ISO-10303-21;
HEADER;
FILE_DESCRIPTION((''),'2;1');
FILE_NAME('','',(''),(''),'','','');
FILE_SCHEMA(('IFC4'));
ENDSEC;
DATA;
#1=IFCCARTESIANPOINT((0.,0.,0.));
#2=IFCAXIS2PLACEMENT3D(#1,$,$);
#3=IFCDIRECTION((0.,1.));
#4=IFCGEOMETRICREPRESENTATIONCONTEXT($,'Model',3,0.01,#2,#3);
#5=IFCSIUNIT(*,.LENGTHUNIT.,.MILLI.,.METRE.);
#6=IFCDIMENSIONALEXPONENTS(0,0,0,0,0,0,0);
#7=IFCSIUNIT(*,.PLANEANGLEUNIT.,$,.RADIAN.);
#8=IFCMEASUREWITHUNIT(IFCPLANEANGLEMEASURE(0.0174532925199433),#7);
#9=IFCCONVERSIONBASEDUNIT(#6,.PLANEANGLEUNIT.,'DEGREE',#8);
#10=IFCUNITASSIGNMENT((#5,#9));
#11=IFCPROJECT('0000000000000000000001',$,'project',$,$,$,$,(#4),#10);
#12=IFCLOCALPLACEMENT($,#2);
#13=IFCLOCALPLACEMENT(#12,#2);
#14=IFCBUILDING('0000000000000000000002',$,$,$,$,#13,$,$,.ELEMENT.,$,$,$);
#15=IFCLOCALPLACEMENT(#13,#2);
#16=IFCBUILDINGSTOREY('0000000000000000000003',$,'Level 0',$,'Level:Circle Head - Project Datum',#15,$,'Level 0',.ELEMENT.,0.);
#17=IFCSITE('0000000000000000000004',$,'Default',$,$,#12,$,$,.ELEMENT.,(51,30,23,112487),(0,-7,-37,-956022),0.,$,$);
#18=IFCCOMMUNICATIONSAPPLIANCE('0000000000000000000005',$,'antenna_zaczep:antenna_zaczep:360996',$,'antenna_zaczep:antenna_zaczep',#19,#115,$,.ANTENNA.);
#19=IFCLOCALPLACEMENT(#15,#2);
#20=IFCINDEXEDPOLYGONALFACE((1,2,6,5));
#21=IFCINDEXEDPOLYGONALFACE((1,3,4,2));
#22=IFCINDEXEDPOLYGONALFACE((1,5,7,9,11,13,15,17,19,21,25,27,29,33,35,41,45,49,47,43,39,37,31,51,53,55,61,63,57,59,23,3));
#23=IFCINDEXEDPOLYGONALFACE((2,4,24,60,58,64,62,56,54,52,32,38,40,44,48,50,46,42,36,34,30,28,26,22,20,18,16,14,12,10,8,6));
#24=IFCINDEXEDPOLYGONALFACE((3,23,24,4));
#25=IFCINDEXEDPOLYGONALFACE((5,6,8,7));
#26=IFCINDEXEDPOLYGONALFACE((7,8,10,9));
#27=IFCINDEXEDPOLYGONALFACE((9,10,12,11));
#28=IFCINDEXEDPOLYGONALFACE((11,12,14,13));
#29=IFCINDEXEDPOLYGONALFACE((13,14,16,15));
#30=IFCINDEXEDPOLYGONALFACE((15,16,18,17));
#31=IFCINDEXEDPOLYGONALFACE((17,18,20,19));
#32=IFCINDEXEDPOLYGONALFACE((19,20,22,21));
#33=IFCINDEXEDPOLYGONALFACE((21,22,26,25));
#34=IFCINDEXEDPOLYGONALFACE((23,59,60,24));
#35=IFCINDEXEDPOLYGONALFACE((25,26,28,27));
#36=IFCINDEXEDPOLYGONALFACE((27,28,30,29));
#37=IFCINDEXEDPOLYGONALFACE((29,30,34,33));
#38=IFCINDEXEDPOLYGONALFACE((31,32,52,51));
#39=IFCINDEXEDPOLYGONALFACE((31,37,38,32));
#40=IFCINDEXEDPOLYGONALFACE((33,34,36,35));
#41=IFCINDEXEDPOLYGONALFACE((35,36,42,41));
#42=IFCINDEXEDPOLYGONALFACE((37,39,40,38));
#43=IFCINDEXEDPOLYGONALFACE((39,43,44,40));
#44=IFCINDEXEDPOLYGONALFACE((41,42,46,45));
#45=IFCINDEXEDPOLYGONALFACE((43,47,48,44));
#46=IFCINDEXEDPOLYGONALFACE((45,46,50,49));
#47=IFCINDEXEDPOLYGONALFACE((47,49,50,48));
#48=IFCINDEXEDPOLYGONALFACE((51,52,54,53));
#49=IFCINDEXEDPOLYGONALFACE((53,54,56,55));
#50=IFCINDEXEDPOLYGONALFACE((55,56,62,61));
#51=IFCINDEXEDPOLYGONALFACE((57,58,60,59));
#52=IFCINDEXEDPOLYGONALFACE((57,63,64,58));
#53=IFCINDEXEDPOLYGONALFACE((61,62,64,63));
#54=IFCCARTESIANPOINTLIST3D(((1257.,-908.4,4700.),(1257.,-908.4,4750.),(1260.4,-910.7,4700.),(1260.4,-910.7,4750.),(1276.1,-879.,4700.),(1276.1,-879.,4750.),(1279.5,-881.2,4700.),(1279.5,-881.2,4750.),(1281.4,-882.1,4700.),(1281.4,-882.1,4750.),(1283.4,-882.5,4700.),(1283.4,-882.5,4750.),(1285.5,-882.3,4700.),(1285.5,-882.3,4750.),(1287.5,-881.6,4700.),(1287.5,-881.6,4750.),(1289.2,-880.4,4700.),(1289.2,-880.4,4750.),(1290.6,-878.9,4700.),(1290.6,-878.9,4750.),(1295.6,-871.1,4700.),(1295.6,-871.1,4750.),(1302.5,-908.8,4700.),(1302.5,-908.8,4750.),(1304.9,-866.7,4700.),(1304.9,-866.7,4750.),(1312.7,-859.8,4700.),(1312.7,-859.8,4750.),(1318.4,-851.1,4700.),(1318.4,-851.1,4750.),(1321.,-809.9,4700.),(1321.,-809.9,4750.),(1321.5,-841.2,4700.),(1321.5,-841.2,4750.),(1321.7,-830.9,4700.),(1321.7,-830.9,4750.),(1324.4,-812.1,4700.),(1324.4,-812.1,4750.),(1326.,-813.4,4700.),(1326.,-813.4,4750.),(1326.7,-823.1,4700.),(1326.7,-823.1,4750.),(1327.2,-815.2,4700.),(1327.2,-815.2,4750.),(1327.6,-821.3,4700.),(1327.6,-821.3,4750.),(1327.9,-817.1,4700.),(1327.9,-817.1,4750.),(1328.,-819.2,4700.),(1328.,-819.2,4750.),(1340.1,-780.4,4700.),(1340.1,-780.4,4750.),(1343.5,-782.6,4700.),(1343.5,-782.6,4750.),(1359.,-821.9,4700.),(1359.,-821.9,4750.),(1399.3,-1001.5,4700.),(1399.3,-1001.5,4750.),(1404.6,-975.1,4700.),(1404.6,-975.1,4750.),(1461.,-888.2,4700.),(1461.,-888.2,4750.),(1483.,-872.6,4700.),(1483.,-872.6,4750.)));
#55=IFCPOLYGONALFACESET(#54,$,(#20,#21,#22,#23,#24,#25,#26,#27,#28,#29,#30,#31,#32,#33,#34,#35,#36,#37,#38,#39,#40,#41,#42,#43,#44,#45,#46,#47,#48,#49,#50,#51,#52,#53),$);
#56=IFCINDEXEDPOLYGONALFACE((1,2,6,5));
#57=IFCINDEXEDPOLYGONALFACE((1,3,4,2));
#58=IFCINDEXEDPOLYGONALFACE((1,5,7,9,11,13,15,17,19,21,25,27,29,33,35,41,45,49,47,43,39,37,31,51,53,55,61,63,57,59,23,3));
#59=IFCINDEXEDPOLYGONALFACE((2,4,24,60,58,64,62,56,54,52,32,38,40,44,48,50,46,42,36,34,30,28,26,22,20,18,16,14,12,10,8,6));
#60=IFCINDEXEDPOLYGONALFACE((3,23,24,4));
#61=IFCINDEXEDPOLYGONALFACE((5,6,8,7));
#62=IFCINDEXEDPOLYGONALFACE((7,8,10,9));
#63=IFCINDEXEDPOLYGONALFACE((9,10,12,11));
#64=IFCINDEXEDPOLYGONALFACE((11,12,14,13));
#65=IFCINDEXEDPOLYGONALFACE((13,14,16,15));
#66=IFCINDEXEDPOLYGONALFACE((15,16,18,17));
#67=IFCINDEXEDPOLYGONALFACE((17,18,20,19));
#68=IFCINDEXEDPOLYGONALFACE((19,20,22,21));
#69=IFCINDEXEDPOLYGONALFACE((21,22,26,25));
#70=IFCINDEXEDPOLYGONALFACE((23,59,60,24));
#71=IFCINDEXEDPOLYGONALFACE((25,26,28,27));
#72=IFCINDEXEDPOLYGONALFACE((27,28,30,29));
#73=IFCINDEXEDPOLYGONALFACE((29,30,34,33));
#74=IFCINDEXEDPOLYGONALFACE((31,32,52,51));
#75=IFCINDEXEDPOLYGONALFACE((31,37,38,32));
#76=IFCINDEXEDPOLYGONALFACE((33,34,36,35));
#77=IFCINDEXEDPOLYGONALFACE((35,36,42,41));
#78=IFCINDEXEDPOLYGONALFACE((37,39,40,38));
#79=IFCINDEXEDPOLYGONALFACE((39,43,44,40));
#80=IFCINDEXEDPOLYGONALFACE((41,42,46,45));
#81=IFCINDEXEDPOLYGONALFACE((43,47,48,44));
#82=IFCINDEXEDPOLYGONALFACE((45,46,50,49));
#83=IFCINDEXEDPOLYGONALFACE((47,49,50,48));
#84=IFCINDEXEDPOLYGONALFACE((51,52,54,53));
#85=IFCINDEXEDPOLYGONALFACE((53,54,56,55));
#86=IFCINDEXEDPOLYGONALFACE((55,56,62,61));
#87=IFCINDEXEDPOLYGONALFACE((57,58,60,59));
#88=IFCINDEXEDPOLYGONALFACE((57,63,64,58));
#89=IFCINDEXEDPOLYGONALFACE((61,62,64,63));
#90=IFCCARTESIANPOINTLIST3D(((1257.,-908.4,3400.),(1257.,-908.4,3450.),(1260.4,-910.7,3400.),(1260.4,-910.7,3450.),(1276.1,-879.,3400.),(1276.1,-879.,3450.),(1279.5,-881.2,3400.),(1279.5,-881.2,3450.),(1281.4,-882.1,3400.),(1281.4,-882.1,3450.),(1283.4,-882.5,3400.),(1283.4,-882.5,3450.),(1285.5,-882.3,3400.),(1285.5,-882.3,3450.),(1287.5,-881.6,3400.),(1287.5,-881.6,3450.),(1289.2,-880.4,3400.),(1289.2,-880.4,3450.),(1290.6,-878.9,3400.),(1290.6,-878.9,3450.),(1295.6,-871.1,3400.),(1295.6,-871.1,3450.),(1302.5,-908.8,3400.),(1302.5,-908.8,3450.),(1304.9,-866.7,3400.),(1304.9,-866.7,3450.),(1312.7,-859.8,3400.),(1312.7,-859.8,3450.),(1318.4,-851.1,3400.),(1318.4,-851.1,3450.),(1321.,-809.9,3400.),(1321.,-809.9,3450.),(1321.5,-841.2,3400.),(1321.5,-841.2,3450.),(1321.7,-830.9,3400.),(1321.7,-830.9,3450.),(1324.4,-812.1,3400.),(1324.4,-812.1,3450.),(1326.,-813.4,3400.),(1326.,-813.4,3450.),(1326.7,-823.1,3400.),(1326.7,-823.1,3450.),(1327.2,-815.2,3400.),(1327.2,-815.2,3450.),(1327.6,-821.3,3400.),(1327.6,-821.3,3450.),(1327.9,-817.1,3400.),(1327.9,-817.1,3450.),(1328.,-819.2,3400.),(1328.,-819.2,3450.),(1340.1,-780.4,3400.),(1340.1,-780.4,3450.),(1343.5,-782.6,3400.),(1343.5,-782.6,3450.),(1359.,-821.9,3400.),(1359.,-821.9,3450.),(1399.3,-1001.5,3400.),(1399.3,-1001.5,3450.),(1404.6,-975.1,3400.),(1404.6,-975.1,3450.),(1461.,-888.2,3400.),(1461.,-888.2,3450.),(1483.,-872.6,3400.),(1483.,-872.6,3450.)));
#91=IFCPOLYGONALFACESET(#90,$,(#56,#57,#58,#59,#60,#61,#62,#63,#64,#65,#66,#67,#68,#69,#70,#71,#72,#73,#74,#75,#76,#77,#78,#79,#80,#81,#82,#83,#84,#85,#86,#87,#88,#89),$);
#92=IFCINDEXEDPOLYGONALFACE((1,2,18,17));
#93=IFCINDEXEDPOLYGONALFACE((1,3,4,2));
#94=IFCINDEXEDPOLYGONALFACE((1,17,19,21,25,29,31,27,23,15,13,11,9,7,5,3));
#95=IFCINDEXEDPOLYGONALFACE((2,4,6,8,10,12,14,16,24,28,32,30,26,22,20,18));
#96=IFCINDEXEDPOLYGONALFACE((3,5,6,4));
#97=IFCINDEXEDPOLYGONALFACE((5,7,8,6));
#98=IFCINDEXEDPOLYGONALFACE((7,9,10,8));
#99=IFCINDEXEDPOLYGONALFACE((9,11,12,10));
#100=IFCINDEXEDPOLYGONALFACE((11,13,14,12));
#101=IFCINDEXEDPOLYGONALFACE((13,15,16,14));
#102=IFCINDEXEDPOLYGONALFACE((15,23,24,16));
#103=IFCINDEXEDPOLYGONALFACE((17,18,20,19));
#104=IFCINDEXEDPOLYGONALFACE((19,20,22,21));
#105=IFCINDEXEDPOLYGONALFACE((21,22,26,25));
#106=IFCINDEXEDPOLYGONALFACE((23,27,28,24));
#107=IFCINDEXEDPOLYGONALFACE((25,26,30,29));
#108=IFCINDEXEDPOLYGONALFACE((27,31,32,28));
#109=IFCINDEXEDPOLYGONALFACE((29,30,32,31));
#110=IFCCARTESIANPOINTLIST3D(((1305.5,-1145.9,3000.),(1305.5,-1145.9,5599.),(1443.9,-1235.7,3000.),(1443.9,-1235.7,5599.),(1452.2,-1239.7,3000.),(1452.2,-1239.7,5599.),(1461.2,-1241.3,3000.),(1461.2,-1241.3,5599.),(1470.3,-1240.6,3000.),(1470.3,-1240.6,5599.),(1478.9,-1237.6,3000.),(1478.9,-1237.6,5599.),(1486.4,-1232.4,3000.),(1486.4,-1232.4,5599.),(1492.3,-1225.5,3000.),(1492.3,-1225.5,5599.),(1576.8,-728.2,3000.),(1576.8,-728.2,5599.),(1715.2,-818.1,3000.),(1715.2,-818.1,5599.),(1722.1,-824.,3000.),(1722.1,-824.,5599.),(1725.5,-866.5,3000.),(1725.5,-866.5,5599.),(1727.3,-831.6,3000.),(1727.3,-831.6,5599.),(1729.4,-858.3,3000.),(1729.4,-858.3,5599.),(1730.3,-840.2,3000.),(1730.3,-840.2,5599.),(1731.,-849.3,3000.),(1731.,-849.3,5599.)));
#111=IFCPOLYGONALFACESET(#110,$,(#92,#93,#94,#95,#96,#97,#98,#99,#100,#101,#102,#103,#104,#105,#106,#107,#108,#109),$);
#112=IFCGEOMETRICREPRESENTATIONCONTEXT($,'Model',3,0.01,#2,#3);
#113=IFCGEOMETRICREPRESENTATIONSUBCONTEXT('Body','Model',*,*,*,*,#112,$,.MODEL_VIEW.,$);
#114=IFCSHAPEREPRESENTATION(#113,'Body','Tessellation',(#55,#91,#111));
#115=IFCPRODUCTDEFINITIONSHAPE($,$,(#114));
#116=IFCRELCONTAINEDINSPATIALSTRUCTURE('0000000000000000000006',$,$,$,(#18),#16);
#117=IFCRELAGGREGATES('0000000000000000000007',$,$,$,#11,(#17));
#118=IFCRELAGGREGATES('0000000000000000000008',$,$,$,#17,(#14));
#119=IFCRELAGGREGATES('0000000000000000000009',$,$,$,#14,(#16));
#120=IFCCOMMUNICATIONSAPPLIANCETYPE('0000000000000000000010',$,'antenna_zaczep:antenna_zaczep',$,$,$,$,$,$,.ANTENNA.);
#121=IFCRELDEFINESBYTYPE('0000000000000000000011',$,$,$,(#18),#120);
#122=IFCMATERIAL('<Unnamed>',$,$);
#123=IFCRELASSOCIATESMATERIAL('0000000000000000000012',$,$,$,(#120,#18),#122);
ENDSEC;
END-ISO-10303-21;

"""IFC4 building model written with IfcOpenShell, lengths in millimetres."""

from ifc_helpers import new_model, entity, si_unit, converted_unit, direction, frame, origin, place, context, subcontext, project, spatial, line, arc, indexed_curve, outline, extrude, source, transform, mapped, material, type_object, type_shapes, element, save


model = new_model("IFC4")

# Units and contexts
model_context_1 = context("Model", 3, precision=0.01, world=origin(), true_north=direction((0.0, 1.0)))
model_context_2 = context("Model", 3, precision=0.01, world=origin(), true_north=direction((0.0, 1.0)))
body_context = subcontext(model_context_2, "Body", "Model", "MODEL_VIEW")
ifc_project = project(units=[si_unit("LENGTHUNIT", "METRE", prefix="MILLI"), converted_unit("PLANEANGLEUNIT", "DEGREE", entity("IfcPlaneAngleMeasure", 0.0174532925199433), si_unit("PLANEANGLEUNIT", "RADIAN"), dimensions=[0, 0, 0, 0, 0, 0, 0])], contexts=[model_context_1])

# Site, building, storey
site_placement = place(None, origin())
site = spatial("IfcSite", under=ifc_project, at=site_placement, Name="Default", CompositionType="ELEMENT", RefLatitude=(51, 30, 23, 112487), RefLongitude=(0, -7, -37, -956022), RefElevation=0.0)
building_placement = place(site_placement, origin())
building = spatial("IfcBuilding", under=site, at=building_placement, CompositionType="ELEMENT")
storey_placement = place(building_placement, origin())
storey = spatial("IfcBuildingStorey", under=building, at=storey_placement, Name="Level 0", ObjectType="Level:Circle Head - Project Datum", LongName="Level 0", CompositionType="ELEMENT", Elevation=0.0)

# Communications appliance
ifc_material_1 = material(Name="<Unnamed>")
communications_appliance_type = type_object("IfcCommunicationsApplianceType", Name="antenna_zaczep:antenna_zaczep", PredefinedType="ANTENNA", material=ifc_material_1)
shared_shape = source(origin(), body_context, "Body", "SweptSolid", [
    extrude(outline(indexed_curve([(-76.8, -125.5), (76.8, -125.5), (51.8, -115.5), (51.8, 6.1), (76.3, 40.5), (76.3, 44.5), (41.2, 44.5), (41.2, 40.5), (38.9, 34.8), (33.2, 32.5), (24.0, 32.5), (0.0, 23.9), (-24.0, 32.5), (-33.2, 32.5), (-38.9, 34.8), (-41.2, 40.5), (-41.2, 44.5), (-76.3, 44.5), (-76.3, 40.5), (-51.8, 6.1), (-51.8, -115.5)], segments=[line(1, 2, 3, 4, 5, 6, 7, 8), arc(8, 9, 10), line(10, 11), arc(11, 12, 13), line(13, 14), arc(14, 15, 16), line(16, 17, 18, 19, 20, 21, 1)], self_intersect=False)), frame((0.0, 61.4, 1700.0), z_axis=(0.0, 0.0, 1.0), x_axis=(-1.0, 0.0, 0.0)), (0.0, 0.0, 1.0), 50.0),
    extrude(outline(indexed_curve([(-76.8, -125.5), (76.8, -125.5), (51.8, -115.5), (51.8, 6.1), (76.3, 40.5), (76.3, 44.5), (41.2, 44.5), (41.2, 40.5), (38.9, 34.8), (33.2, 32.5), (24.0, 32.5), (0.0, 23.9), (-24.0, 32.5), (-33.2, 32.5), (-38.9, 34.8), (-41.2, 40.5), (-41.2, 44.5), (-76.3, 44.5), (-76.3, 40.5), (-51.8, 6.1), (-51.8, -115.5)], segments=[line(1, 2, 3, 4, 5, 6, 7, 8), arc(8, 9, 10), line(10, 11), arc(11, 12, 13), line(13, 14), arc(14, 15, 16), line(16, 17, 18, 19, 20, 21, 1)], self_intersect=False)), frame((0.0, 61.4, 400.0), z_axis=(0.0, 0.0, 1.0), x_axis=(-1.0, 0.0, 0.0)), (0.0, 0.0, 1.0), 50.0),
    extrude(outline(indexed_curve([(-214.0, -78.3), (214.0, -78.3), (238.7, -68.1), (249.0, -43.3), (249.0, 121.7), (-249.0, 121.7), (-249.0, -43.3), (-238.7, -68.1)], segments=[line(1, 2), arc(2, 3, 4), line(4, 5, 6, 7), arc(7, 8, 1)], self_intersect=False)), frame((0.0, 308.6, 0.0), z_axis=(0.0, 0.0, 1.0), x_axis=(-1.0, 0.0, 0.0)), (0.0, 0.0, 1.0), 2599.0),
])
type_shapes(communications_appliance_type, [shared_shape])
communications_appliance_placement = place(storey_placement, frame((1284.4, -835.3, 3000.0), z_axis=(0.0, 0.0, 1.0), x_axis=(-0.544639, -0.838671, 0.0)))
element("IfcCommunicationsAppliance", 1, at=communications_appliance_placement, inside=storey, type_object=communications_appliance_type, material=ifc_material_1, Name="antenna_zaczep:antenna_zaczep:360996", ObjectType="antenna_zaczep:antenna_zaczep", PredefinedType="ANTENNA", context=body_context, shape_type="MappedRepresentation", body=[
    mapped(shared_shape, transform((0.0, 0.0, 0.0), scale=1.0)),
])

save(model, "model.ifc")
